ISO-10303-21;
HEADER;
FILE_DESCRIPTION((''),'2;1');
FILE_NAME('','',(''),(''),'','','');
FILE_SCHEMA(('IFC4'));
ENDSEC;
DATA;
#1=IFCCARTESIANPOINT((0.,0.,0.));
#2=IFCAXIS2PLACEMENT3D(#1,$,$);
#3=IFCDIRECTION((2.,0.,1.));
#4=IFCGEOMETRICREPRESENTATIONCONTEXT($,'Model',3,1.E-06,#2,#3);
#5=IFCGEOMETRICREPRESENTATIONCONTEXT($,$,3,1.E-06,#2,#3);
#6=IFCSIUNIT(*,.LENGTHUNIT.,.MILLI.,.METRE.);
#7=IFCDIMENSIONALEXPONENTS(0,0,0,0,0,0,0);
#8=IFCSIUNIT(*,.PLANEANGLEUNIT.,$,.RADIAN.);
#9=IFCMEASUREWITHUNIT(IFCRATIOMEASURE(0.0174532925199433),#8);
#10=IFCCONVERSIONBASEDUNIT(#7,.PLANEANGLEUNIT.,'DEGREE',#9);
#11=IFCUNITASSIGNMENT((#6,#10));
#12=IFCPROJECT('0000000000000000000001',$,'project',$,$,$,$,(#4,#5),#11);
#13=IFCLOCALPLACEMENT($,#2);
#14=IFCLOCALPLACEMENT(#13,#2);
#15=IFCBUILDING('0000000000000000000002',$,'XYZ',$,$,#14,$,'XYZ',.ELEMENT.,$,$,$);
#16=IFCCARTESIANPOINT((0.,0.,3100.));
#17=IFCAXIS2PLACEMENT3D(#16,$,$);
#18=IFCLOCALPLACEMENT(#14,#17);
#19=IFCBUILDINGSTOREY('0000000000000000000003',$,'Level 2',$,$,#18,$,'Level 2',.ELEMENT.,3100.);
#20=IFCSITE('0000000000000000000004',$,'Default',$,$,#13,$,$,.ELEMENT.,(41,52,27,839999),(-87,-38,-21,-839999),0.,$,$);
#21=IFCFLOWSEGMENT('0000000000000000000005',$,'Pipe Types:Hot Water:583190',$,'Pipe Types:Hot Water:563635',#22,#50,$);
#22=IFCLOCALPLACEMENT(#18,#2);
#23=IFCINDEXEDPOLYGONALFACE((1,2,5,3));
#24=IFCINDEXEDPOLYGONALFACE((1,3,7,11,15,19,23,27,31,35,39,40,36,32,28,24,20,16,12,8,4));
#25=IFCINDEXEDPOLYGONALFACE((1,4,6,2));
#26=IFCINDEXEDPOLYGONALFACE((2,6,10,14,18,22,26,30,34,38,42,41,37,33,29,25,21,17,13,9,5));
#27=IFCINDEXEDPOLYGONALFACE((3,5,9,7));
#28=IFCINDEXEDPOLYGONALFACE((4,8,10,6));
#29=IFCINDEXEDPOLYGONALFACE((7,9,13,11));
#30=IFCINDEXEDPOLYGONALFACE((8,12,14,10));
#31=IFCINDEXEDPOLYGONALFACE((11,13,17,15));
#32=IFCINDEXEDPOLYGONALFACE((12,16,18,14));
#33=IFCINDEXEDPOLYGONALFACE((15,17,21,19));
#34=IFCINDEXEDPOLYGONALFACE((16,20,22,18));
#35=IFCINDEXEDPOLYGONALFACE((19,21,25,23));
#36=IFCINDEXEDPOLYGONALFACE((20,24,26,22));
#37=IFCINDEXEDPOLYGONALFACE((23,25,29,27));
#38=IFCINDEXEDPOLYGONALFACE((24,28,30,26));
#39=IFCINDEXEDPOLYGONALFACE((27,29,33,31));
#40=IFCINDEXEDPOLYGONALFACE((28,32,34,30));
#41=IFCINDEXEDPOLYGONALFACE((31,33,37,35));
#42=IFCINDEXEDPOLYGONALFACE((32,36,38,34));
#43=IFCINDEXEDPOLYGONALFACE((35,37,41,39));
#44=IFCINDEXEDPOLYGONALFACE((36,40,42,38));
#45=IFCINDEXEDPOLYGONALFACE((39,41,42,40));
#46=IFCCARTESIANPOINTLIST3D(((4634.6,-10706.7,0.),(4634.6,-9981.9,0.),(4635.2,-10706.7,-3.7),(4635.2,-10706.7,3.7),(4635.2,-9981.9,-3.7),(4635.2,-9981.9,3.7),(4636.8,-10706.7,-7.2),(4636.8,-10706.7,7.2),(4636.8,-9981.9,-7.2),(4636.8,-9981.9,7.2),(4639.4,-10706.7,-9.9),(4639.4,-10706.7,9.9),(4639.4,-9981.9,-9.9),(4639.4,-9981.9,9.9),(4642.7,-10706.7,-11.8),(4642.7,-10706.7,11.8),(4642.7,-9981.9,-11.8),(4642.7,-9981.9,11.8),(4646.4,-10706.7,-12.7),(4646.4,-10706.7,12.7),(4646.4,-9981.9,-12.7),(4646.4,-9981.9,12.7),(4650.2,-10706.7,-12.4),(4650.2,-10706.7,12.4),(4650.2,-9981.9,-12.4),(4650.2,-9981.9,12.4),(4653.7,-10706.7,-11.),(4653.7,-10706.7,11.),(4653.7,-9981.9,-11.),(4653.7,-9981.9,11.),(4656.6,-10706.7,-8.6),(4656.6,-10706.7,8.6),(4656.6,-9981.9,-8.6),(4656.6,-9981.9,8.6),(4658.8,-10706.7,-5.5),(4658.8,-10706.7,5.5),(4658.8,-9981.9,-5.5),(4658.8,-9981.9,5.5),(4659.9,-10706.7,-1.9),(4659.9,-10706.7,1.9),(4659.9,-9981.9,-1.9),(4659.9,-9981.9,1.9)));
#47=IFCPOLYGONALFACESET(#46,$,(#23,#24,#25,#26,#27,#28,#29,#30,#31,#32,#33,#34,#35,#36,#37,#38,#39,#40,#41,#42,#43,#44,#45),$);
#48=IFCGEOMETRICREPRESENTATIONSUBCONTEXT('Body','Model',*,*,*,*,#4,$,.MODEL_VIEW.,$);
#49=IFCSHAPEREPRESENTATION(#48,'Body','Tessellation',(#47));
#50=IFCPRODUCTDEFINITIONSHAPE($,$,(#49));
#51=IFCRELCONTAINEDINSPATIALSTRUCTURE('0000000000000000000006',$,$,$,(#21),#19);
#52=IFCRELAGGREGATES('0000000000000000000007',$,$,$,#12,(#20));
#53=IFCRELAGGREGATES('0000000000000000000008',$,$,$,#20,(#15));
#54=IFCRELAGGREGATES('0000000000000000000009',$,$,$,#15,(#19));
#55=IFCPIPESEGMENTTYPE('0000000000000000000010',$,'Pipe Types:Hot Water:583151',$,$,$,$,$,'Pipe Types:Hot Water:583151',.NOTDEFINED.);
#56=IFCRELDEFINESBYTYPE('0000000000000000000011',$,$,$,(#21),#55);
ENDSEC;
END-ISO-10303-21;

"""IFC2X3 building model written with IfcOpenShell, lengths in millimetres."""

from ifc_helpers import new_model, entity, si_unit, converted_unit, direction, frame, frame_2d, origin, place, context, subcontext, project, spatial, circle, extrude, type_object, element, save


model = new_model("IFC2X3")

# Units and contexts
model_context = context("Model", 3, precision=1e-06, world=origin(), true_north=direction((2.0, 0.0, 1.0)))
context_of_model = context(None, 3, precision=1e-06, world=origin(), true_north=direction((2.0, 0.0, 1.0)))
body_context = subcontext(model_context, "Body", "Model", "MODEL_VIEW")
ifc_project = project(units=[si_unit("LENGTHUNIT", "METRE", prefix="MILLI"), converted_unit("PLANEANGLEUNIT", "DEGREE", entity("IfcRatioMeasure", 0.0174532925199433), si_unit("PLANEANGLEUNIT", "RADIAN"), dimensions=[0, 0, 0, 0, 0, 0, 0])], contexts=[model_context, context_of_model])

# Site, building, storey
site_placement = place(None, origin())
site = spatial("IfcSite", under=ifc_project, at=site_placement, Name="Default", CompositionType="ELEMENT", RefLatitude=(41, 52, 27, 839999), RefLongitude=(-87, -38, -21, -839999), RefElevation=0.0)
building_placement = place(site_placement, origin())
building = spatial("IfcBuilding", under=site, at=building_placement, Name="XYZ", LongName="XYZ", CompositionType="ELEMENT")
storey_placement = place(building_placement, frame((0.0, 0.0, 3100.0)))
storey = spatial("IfcBuildingStorey", under=building, at=storey_placement, Name="Level 2", LongName="Level 2", CompositionType="ELEMENT", Elevation=3100.0)

# Flow segment
pipe_segment_type_1 = type_object("IfcPipeSegmentType", Name="Pipe Types:Hot Water:583151", ElementType="Pipe Types:Hot Water:583151", PredefinedType="NOTDEFINED")
flow_segment_1_placement = place(storey_placement, origin())
element("IfcFlowSegment", 1, at=flow_segment_1_placement, inside=storey, type_object=pipe_segment_type_1, Name="Pipe Types:Hot Water:583190", ObjectType="Pipe Types:Hot Water:563635", context=body_context, shape_type="SweptSolid", body=[
    extrude(circle(Radius=12.7, at=frame_2d((0.0, 0.0), x_axis=(1.0, 0.0))), frame((4647.3, -10706.7, 0.0), z_axis=(0.0, 1.0, 0.0), x_axis=(-1.0, 0.0, 0.0)), (0.0, 0.0, 1.0), 724.8),
])

save(model, "model.ifc")
